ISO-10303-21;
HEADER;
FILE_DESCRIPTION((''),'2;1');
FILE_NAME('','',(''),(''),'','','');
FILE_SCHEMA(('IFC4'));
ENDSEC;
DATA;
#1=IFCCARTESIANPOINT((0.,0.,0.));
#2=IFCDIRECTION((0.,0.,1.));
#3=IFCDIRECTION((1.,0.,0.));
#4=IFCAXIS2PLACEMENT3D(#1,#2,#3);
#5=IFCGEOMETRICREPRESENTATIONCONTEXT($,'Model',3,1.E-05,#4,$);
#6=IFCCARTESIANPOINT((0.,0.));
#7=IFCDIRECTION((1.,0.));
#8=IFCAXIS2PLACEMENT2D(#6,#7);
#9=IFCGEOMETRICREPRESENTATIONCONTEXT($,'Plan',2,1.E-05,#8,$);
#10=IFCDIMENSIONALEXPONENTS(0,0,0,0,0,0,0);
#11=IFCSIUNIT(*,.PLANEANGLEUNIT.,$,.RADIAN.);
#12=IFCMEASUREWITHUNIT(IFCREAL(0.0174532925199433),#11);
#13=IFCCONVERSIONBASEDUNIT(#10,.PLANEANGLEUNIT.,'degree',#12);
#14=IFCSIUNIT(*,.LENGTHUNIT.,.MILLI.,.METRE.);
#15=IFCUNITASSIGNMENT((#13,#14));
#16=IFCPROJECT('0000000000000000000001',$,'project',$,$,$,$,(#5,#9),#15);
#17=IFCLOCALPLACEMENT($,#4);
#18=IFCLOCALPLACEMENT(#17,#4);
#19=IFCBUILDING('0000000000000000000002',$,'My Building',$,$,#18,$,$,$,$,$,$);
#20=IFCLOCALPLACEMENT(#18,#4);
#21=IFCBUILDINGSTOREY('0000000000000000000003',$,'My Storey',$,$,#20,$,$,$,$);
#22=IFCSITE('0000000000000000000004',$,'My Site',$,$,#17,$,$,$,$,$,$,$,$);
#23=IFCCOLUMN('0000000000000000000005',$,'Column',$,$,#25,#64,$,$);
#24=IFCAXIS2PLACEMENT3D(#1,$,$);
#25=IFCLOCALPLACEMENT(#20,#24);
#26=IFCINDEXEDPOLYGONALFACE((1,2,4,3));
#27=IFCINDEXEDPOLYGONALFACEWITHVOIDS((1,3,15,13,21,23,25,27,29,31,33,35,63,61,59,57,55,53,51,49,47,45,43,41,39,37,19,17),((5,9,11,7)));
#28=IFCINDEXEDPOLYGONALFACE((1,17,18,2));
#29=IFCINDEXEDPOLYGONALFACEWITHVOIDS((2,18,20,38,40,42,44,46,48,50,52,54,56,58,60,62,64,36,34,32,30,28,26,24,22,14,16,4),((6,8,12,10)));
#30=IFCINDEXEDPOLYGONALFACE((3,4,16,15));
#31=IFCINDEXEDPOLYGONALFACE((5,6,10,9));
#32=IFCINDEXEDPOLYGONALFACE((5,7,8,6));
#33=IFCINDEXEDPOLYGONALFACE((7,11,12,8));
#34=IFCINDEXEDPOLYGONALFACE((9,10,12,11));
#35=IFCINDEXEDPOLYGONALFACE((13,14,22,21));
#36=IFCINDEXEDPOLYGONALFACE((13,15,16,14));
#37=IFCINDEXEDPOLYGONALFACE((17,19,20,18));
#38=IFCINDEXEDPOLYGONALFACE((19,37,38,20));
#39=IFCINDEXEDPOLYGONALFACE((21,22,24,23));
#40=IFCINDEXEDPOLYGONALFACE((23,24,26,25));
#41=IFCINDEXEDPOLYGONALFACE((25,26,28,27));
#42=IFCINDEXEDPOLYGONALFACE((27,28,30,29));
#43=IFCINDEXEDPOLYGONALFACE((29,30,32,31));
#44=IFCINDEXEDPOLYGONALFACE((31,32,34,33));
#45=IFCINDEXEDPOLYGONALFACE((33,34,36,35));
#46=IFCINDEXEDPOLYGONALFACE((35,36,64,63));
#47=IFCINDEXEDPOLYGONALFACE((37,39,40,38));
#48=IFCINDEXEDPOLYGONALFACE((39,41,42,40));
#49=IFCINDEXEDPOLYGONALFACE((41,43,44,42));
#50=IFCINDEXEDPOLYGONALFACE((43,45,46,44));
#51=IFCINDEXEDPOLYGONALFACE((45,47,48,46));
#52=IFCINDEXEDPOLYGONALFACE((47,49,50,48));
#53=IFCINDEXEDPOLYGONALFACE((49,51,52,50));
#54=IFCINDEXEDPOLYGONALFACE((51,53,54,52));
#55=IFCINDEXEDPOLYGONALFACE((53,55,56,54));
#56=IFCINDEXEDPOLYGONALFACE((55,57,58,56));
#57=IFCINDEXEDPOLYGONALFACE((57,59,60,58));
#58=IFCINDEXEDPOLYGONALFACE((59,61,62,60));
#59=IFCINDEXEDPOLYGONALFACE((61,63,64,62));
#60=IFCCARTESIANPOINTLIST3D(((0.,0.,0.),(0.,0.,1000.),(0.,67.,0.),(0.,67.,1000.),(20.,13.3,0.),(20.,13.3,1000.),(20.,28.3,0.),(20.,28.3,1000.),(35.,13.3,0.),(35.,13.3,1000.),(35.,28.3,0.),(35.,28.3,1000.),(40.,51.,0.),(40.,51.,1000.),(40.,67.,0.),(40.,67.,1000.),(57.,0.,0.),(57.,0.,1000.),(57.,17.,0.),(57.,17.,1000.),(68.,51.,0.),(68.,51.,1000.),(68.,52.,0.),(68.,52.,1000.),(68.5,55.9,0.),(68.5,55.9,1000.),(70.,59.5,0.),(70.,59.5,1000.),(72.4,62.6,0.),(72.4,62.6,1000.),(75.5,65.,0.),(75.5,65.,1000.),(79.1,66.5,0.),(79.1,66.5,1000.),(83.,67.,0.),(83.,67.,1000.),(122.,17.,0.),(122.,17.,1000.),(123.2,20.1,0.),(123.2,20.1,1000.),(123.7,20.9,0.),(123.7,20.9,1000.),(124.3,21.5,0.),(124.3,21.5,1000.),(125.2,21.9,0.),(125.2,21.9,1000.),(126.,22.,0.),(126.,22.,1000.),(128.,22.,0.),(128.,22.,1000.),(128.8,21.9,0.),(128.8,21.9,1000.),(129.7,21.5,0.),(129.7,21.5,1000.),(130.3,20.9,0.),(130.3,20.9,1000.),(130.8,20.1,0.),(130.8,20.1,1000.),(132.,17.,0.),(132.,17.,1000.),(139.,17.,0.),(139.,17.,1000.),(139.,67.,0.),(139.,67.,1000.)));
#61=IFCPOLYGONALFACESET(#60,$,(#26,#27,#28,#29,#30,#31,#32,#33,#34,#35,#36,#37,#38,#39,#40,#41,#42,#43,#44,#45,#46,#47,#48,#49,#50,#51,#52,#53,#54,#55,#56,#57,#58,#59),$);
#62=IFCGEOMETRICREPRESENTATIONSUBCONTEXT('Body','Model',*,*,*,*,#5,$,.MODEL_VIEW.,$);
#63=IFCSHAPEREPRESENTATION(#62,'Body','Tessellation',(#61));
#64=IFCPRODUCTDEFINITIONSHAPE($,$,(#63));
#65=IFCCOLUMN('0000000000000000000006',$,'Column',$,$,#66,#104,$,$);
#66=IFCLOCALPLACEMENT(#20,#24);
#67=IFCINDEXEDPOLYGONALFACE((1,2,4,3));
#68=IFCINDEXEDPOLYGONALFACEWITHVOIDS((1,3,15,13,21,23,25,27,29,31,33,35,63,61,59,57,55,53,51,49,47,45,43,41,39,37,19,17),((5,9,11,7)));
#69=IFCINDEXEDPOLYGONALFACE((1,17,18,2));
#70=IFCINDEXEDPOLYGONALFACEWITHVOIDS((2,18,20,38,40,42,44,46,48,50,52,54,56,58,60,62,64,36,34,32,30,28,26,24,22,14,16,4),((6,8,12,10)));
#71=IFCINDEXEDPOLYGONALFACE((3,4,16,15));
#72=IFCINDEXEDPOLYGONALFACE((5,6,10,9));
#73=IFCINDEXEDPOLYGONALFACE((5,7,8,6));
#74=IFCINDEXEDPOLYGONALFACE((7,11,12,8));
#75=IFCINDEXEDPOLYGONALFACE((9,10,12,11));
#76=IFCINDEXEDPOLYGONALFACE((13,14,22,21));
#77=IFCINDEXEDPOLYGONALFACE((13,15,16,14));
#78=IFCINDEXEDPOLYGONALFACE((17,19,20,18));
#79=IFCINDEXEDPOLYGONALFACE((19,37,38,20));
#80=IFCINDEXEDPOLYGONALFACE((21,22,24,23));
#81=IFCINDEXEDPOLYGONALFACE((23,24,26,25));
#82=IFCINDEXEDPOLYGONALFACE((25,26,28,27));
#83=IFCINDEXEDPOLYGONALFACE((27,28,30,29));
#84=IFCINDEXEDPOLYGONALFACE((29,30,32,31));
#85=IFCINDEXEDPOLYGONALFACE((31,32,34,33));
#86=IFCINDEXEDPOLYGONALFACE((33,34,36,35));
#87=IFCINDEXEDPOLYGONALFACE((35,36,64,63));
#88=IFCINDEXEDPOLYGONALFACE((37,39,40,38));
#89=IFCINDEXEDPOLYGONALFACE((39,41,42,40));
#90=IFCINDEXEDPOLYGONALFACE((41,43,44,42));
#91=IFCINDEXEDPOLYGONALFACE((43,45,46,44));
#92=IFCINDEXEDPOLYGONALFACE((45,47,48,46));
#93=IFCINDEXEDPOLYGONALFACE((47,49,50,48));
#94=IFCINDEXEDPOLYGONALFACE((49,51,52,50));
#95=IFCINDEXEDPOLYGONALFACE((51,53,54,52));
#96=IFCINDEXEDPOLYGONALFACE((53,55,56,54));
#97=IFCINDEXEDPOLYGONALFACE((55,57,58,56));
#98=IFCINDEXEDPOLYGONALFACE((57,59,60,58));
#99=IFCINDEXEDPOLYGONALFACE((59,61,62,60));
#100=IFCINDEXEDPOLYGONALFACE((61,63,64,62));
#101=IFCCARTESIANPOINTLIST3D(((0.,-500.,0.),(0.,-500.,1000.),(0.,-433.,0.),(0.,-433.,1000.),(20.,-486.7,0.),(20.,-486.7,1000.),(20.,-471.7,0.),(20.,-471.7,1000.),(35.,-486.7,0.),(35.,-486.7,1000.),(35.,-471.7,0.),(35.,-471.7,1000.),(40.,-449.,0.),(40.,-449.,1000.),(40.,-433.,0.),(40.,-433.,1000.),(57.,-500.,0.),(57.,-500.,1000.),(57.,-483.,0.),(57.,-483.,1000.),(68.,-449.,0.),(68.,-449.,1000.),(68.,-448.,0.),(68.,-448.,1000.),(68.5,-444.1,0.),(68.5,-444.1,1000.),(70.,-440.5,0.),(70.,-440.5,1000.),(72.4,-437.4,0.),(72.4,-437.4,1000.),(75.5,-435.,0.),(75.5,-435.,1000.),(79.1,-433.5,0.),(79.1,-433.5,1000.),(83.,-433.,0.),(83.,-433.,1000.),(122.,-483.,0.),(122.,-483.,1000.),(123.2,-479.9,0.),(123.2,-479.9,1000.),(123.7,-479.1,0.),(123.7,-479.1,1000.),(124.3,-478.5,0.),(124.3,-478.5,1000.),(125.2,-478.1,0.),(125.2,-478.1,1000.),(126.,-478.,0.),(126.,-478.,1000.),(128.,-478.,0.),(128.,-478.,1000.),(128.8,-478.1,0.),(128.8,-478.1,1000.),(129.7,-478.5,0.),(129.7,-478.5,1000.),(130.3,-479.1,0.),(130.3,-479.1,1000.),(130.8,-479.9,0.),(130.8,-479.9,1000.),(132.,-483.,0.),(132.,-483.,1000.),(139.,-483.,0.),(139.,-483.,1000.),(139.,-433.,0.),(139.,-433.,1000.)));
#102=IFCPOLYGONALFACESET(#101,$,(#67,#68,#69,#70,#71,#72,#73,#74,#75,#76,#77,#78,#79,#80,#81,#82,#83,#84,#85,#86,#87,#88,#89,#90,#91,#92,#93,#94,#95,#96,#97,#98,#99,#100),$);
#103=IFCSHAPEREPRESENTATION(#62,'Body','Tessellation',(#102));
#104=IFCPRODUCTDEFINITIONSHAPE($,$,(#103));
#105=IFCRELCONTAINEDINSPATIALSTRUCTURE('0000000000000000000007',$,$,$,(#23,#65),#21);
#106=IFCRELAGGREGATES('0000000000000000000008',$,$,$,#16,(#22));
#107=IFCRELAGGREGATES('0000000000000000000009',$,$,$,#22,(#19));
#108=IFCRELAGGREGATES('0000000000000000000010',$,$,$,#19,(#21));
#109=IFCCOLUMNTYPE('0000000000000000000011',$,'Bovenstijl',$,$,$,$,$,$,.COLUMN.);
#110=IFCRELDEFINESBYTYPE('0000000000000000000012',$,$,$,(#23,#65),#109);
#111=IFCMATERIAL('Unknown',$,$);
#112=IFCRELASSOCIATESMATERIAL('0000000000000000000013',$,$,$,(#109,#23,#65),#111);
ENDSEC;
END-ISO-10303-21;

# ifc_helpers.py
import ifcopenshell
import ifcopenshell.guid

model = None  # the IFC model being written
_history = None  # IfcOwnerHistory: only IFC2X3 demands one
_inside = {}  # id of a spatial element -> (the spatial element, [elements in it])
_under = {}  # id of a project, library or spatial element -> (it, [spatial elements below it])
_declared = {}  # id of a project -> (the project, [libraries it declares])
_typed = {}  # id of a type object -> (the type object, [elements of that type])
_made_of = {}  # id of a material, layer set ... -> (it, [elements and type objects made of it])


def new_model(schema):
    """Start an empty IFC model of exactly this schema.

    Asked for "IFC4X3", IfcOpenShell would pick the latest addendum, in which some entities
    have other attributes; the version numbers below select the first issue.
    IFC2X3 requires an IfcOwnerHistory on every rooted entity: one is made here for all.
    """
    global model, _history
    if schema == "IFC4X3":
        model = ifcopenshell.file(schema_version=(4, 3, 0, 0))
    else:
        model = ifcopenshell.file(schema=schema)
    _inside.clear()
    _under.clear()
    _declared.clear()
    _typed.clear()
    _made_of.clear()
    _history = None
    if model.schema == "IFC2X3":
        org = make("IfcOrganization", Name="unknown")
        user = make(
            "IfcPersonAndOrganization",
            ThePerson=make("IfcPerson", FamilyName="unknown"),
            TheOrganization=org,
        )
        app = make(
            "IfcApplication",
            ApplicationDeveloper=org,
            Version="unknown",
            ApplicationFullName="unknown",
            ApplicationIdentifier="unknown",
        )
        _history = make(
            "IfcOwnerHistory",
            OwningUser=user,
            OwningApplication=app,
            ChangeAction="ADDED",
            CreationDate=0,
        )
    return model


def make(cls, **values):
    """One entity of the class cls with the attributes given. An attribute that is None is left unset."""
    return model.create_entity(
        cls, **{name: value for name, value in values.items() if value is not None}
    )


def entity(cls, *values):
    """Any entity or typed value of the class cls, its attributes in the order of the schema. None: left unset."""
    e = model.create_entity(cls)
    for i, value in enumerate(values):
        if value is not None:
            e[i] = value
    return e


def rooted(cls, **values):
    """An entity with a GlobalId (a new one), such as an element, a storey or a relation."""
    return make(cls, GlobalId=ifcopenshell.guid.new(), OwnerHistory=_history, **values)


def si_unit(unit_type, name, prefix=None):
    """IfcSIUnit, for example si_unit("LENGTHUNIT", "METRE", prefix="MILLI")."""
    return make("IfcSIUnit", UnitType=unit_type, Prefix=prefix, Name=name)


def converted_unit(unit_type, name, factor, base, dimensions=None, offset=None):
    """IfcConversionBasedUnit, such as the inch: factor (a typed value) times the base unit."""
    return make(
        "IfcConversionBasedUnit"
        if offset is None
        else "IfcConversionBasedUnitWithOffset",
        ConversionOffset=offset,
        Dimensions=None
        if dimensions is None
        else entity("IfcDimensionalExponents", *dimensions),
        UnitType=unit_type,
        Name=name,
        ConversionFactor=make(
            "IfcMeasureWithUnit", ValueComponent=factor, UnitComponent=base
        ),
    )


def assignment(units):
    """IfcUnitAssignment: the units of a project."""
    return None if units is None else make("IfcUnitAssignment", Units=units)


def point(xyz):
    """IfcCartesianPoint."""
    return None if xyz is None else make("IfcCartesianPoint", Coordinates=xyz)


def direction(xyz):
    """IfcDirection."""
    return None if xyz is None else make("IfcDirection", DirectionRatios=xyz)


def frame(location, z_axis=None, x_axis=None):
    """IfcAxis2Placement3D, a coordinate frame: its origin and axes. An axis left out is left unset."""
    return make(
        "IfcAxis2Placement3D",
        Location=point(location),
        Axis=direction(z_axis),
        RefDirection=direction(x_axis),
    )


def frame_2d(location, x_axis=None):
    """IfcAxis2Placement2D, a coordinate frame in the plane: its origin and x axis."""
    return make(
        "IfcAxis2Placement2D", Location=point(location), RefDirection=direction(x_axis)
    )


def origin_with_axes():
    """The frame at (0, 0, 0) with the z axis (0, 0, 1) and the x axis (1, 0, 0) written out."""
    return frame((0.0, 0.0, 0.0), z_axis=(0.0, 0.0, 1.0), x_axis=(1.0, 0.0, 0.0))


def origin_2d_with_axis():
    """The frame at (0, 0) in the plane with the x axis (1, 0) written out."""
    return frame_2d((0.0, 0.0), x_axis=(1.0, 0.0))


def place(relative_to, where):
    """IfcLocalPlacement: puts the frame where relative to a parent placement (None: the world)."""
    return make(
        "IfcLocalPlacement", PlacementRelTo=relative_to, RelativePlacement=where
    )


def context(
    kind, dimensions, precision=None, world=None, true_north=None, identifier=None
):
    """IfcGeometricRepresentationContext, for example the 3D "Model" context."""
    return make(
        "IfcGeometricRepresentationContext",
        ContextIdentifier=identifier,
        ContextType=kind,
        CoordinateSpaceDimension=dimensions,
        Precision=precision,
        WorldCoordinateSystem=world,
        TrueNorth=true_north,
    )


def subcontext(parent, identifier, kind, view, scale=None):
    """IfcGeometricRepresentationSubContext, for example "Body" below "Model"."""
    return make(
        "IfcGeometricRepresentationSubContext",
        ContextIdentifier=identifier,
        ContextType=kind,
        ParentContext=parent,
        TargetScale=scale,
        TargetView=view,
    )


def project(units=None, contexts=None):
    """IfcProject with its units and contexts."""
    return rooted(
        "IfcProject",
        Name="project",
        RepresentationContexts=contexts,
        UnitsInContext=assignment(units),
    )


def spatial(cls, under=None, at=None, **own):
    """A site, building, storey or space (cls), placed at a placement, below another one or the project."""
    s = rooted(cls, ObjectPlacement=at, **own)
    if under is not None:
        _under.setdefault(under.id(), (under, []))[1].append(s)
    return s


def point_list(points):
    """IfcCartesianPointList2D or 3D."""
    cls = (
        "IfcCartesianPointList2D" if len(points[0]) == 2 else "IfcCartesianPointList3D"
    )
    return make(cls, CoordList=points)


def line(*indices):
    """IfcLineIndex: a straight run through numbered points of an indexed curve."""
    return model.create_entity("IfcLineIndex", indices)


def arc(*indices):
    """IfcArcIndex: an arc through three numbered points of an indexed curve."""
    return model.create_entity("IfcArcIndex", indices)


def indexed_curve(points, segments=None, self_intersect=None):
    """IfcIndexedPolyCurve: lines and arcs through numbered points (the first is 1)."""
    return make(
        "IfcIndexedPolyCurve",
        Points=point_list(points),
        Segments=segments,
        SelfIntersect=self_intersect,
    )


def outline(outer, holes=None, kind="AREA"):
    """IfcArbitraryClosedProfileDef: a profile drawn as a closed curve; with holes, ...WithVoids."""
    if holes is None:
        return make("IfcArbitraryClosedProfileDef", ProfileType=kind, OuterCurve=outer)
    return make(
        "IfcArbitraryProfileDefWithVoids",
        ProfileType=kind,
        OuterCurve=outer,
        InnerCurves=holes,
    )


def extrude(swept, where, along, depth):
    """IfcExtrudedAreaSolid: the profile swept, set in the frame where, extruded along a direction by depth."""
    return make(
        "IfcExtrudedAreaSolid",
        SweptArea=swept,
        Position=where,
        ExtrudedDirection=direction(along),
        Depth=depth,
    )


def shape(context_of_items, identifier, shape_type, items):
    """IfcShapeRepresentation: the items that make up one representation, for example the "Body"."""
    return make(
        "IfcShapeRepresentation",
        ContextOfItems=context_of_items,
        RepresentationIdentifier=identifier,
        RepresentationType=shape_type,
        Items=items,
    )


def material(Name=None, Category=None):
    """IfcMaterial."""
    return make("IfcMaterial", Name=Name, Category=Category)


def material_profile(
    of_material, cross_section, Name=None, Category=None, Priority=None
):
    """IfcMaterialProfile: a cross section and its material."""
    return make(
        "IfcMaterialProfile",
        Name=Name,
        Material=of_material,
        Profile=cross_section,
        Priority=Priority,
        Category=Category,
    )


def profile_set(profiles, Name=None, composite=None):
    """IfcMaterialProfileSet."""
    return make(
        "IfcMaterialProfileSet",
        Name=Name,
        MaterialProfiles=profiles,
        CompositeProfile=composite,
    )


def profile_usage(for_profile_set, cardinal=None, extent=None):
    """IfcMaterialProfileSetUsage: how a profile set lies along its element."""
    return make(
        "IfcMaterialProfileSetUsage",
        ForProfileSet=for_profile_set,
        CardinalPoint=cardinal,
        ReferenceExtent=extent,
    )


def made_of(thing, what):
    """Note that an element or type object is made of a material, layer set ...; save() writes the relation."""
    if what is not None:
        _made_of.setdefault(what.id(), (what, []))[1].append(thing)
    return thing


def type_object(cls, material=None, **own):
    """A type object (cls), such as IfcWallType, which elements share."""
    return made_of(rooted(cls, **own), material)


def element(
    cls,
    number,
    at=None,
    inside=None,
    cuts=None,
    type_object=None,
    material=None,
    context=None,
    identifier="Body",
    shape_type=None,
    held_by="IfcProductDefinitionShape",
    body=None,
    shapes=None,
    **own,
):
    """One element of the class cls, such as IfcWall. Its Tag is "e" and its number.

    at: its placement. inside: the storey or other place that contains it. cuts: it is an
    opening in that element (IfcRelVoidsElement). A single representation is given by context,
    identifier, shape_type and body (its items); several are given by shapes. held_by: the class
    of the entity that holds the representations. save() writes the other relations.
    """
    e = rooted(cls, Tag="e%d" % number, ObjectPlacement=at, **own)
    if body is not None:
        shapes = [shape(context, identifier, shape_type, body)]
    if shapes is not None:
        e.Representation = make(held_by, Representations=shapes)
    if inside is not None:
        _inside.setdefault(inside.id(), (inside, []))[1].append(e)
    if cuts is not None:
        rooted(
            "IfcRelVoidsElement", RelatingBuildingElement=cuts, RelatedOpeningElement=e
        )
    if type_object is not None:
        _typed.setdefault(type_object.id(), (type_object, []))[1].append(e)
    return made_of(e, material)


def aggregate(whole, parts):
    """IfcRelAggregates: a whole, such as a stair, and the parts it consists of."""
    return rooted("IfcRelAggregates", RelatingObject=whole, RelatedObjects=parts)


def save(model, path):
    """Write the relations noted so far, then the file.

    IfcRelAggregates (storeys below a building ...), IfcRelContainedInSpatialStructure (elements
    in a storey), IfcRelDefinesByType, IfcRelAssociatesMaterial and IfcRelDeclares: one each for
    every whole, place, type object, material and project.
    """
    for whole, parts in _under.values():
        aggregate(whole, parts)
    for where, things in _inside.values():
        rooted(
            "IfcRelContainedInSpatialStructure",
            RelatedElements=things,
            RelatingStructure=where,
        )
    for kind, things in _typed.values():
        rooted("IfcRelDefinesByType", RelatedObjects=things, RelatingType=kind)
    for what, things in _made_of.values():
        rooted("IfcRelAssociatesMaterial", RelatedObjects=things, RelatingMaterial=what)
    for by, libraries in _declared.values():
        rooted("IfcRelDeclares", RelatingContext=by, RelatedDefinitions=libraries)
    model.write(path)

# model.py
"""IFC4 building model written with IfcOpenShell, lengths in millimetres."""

from ifc_helpers import new_model, entity, si_unit, converted_unit, frame, origin_with_axes, origin_2d_with_axis, place, context, subcontext, project, spatial, line, arc, indexed_curve, outline, extrude, material, material_profile, profile_set, profile_usage, type_object, element, save


model = new_model("IFC4")

# Units and contexts
model_context = context("Model", 3, precision=1e-05, world=origin_with_axes())
plan_context = context("Plan", 2, precision=1e-05, world=origin_2d_with_axis())
body_context = subcontext(model_context, "Body", "Model", "MODEL_VIEW")
ifc_project = project(units=[converted_unit("PLANEANGLEUNIT", "degree", entity("IfcReal", 0.0174532925199433), si_unit("PLANEANGLEUNIT", "RADIAN"), dimensions=[0, 0, 0, 0, 0, 0, 0]), si_unit("LENGTHUNIT", "METRE", prefix="MILLI")], contexts=[model_context, plan_context])

# Site, building, storey
site_placement = place(None, origin_with_axes())
site = spatial("IfcSite", under=ifc_project, at=site_placement, Name="My Site")
building_placement = place(site_placement, origin_with_axes())
building = spatial("IfcBuilding", under=site, at=building_placement, Name="My Building")
storey_placement = place(building_placement, origin_with_axes())
storey = spatial("IfcBuildingStorey", under=building, at=storey_placement, Name="My Storey")

# Columns
ifc_material = material(Name="Unknown")
ifc_material_profile = material_profile(ifc_material, outline(indexed_curve([(122.0, 17.0), (57.0, 17.0), (57.0, 0.0), (0.0, 0.0), (0.0, 67.0), (40.0, 67.0), (40.0, 51.0), (68.0, 51.0), (68.0, 52.0), (72.4, 62.6), (83.0, 67.0), (139.0, 67.0), (139.0, 17.0), (132.0, 17.0), (130.8, 20.1), (129.7, 21.5), (128.0, 22.0), (126.0, 22.0), (124.3, 21.5), (123.2, 20.1), (35.0, 28.3), (20.0, 28.3), (20.0, 13.3), (35.0, 13.3)], segments=[line(5, 4), line(4, 3), line(3, 2), line(2, 1), line(1, 20), arc(20, 19, 18), line(18, 17), arc(17, 16, 15), line(15, 14), line(14, 13), line(13, 12), line(12, 11), arc(11, 10, 9), line(9, 8), line(8, 7), line(7, 6), line(6, 5)], self_intersect=False), holes=[indexed_curve([(122.0, 17.0), (57.0, 17.0), (57.0, 0.0), (0.0, 0.0), (0.0, 67.0), (40.0, 67.0), (40.0, 51.0), (68.0, 51.0), (68.0, 52.0), (72.4, 62.6), (83.0, 67.0), (139.0, 67.0), (139.0, 17.0), (132.0, 17.0), (130.8, 20.1), (129.7, 21.5), (128.0, 22.0), (126.0, 22.0), (124.3, 21.5), (123.2, 20.1), (35.0, 28.3), (20.0, 28.3), (20.0, 13.3), (35.0, 13.3)], segments=[line(22, 23), line(23, 24), line(24, 21), line(21, 22)], self_intersect=False)]))
ifc_profile_set = profile_set([ifc_material_profile])
ifc_profile_usage_1 = profile_usage(ifc_profile_set, cardinal=5)
column_type = type_object("IfcColumnType", Name="Bovenstijl", PredefinedType="COLUMN", material=ifc_profile_set)
column_1_placement = place(storey_placement, origin_with_axes())
element("IfcColumn", 1, at=column_1_placement, inside=storey, type_object=column_type, material=ifc_profile_usage_1, Name="Column", context=body_context, shape_type="SweptSolid", body=[
    extrude(outline(indexed_curve([(122.0, 17.0), (57.0, 17.0), (57.0, 0.0), (0.0, 0.0), (0.0, 67.0), (40.0, 67.0), (40.0, 51.0), (68.0, 51.0), (68.0, 52.0), (72.4, 62.6), (83.0, 67.0), (139.0, 67.0), (139.0, 17.0), (132.0, 17.0), (130.8, 20.1), (129.7, 21.5), (128.0, 22.0), (126.0, 22.0), (124.3, 21.5), (123.2, 20.1), (35.0, 28.3), (20.0, 28.3), (20.0, 13.3), (35.0, 13.3)], segments=[line(5, 4), line(4, 3), line(3, 2), line(2, 1), line(1, 20), arc(20, 19, 18), line(18, 17), arc(17, 16, 15), line(15, 14), line(14, 13), line(13, 12), line(12, 11), arc(11, 10, 9), line(9, 8), line(8, 7), line(7, 6), line(6, 5)], self_intersect=False), holes=[indexed_curve([(122.0, 17.0), (57.0, 17.0), (57.0, 0.0), (0.0, 0.0), (0.0, 67.0), (40.0, 67.0), (40.0, 51.0), (68.0, 51.0), (68.0, 52.0), (72.4, 62.6), (83.0, 67.0), (139.0, 67.0), (139.0, 17.0), (132.0, 17.0), (130.8, 20.1), (129.7, 21.5), (128.0, 22.0), (126.0, 22.0), (124.3, 21.5), (123.2, 20.1), (35.0, 28.3), (20.0, 28.3), (20.0, 13.3), (35.0, 13.3)], segments=[line(22, 23), line(23, 24), line(24, 21), line(21, 22)], self_intersect=False)]), origin_with_axes(), (0.0, 0.0, 1.0), 1000.0),
])
ifc_profile_usage_2 = profile_usage(ifc_profile_set, cardinal=5)
column_2_placement = place(storey_placement, frame((0.0, -500.0, 0.0), z_axis=(0.0, 0.0, 1.0), x_axis=(1.0, 0.0, 0.0)))
element("IfcColumn", 2, at=column_2_placement, inside=storey, type_object=column_type, material=ifc_profile_usage_2, Name="Column", context=body_context, shape_type="SweptSolid", body=[
    extrude(outline(indexed_curve([(122.0, 17.0), (57.0, 17.0), (57.0, 0.0), (0.0, 0.0), (0.0, 67.0), (40.0, 67.0), (40.0, 51.0), (68.0, 51.0), (68.0, 52.0), (72.4, 62.6), (83.0, 67.0), (139.0, 67.0), (139.0, 17.0), (132.0, 17.0), (130.8, 20.1), (129.7, 21.5), (128.0, 22.0), (126.0, 22.0), (124.3, 21.5), (123.2, 20.1), (35.0, 28.3), (20.0, 28.3), (20.0, 13.3), (35.0, 13.3)], segments=[line(5, 4), line(4, 3), line(3, 2), line(2, 1), line(1, 20), arc(20, 19, 18), line(18, 17), arc(17, 16, 15), line(15, 14), line(14, 13), line(13, 12), line(12, 11), arc(11, 10, 9), line(9, 8), line(8, 7), line(7, 6), line(6, 5)], self_intersect=False), holes=[indexed_curve([(122.0, 17.0), (57.0, 17.0), (57.0, 0.0), (0.0, 0.0), (0.0, 67.0), (40.0, 67.0), (40.0, 51.0), (68.0, 51.0), (68.0, 52.0), (72.4, 62.6), (83.0, 67.0), (139.0, 67.0), (139.0, 17.0), (132.0, 17.0), (130.8, 20.1), (129.7, 21.5), (128.0, 22.0), (126.0, 22.0), (124.3, 21.5), (123.2, 20.1), (35.0, 28.3), (20.0, 28.3), (20.0, 13.3), (35.0, 13.3)], segments=[line(22, 23), line(23, 24), line(24, 21), line(21, 22)], self_intersect=False)]), origin_with_axes(), (0.0, 0.0, 1.0), 1000.0),
])

save(model, "model.ifc")
